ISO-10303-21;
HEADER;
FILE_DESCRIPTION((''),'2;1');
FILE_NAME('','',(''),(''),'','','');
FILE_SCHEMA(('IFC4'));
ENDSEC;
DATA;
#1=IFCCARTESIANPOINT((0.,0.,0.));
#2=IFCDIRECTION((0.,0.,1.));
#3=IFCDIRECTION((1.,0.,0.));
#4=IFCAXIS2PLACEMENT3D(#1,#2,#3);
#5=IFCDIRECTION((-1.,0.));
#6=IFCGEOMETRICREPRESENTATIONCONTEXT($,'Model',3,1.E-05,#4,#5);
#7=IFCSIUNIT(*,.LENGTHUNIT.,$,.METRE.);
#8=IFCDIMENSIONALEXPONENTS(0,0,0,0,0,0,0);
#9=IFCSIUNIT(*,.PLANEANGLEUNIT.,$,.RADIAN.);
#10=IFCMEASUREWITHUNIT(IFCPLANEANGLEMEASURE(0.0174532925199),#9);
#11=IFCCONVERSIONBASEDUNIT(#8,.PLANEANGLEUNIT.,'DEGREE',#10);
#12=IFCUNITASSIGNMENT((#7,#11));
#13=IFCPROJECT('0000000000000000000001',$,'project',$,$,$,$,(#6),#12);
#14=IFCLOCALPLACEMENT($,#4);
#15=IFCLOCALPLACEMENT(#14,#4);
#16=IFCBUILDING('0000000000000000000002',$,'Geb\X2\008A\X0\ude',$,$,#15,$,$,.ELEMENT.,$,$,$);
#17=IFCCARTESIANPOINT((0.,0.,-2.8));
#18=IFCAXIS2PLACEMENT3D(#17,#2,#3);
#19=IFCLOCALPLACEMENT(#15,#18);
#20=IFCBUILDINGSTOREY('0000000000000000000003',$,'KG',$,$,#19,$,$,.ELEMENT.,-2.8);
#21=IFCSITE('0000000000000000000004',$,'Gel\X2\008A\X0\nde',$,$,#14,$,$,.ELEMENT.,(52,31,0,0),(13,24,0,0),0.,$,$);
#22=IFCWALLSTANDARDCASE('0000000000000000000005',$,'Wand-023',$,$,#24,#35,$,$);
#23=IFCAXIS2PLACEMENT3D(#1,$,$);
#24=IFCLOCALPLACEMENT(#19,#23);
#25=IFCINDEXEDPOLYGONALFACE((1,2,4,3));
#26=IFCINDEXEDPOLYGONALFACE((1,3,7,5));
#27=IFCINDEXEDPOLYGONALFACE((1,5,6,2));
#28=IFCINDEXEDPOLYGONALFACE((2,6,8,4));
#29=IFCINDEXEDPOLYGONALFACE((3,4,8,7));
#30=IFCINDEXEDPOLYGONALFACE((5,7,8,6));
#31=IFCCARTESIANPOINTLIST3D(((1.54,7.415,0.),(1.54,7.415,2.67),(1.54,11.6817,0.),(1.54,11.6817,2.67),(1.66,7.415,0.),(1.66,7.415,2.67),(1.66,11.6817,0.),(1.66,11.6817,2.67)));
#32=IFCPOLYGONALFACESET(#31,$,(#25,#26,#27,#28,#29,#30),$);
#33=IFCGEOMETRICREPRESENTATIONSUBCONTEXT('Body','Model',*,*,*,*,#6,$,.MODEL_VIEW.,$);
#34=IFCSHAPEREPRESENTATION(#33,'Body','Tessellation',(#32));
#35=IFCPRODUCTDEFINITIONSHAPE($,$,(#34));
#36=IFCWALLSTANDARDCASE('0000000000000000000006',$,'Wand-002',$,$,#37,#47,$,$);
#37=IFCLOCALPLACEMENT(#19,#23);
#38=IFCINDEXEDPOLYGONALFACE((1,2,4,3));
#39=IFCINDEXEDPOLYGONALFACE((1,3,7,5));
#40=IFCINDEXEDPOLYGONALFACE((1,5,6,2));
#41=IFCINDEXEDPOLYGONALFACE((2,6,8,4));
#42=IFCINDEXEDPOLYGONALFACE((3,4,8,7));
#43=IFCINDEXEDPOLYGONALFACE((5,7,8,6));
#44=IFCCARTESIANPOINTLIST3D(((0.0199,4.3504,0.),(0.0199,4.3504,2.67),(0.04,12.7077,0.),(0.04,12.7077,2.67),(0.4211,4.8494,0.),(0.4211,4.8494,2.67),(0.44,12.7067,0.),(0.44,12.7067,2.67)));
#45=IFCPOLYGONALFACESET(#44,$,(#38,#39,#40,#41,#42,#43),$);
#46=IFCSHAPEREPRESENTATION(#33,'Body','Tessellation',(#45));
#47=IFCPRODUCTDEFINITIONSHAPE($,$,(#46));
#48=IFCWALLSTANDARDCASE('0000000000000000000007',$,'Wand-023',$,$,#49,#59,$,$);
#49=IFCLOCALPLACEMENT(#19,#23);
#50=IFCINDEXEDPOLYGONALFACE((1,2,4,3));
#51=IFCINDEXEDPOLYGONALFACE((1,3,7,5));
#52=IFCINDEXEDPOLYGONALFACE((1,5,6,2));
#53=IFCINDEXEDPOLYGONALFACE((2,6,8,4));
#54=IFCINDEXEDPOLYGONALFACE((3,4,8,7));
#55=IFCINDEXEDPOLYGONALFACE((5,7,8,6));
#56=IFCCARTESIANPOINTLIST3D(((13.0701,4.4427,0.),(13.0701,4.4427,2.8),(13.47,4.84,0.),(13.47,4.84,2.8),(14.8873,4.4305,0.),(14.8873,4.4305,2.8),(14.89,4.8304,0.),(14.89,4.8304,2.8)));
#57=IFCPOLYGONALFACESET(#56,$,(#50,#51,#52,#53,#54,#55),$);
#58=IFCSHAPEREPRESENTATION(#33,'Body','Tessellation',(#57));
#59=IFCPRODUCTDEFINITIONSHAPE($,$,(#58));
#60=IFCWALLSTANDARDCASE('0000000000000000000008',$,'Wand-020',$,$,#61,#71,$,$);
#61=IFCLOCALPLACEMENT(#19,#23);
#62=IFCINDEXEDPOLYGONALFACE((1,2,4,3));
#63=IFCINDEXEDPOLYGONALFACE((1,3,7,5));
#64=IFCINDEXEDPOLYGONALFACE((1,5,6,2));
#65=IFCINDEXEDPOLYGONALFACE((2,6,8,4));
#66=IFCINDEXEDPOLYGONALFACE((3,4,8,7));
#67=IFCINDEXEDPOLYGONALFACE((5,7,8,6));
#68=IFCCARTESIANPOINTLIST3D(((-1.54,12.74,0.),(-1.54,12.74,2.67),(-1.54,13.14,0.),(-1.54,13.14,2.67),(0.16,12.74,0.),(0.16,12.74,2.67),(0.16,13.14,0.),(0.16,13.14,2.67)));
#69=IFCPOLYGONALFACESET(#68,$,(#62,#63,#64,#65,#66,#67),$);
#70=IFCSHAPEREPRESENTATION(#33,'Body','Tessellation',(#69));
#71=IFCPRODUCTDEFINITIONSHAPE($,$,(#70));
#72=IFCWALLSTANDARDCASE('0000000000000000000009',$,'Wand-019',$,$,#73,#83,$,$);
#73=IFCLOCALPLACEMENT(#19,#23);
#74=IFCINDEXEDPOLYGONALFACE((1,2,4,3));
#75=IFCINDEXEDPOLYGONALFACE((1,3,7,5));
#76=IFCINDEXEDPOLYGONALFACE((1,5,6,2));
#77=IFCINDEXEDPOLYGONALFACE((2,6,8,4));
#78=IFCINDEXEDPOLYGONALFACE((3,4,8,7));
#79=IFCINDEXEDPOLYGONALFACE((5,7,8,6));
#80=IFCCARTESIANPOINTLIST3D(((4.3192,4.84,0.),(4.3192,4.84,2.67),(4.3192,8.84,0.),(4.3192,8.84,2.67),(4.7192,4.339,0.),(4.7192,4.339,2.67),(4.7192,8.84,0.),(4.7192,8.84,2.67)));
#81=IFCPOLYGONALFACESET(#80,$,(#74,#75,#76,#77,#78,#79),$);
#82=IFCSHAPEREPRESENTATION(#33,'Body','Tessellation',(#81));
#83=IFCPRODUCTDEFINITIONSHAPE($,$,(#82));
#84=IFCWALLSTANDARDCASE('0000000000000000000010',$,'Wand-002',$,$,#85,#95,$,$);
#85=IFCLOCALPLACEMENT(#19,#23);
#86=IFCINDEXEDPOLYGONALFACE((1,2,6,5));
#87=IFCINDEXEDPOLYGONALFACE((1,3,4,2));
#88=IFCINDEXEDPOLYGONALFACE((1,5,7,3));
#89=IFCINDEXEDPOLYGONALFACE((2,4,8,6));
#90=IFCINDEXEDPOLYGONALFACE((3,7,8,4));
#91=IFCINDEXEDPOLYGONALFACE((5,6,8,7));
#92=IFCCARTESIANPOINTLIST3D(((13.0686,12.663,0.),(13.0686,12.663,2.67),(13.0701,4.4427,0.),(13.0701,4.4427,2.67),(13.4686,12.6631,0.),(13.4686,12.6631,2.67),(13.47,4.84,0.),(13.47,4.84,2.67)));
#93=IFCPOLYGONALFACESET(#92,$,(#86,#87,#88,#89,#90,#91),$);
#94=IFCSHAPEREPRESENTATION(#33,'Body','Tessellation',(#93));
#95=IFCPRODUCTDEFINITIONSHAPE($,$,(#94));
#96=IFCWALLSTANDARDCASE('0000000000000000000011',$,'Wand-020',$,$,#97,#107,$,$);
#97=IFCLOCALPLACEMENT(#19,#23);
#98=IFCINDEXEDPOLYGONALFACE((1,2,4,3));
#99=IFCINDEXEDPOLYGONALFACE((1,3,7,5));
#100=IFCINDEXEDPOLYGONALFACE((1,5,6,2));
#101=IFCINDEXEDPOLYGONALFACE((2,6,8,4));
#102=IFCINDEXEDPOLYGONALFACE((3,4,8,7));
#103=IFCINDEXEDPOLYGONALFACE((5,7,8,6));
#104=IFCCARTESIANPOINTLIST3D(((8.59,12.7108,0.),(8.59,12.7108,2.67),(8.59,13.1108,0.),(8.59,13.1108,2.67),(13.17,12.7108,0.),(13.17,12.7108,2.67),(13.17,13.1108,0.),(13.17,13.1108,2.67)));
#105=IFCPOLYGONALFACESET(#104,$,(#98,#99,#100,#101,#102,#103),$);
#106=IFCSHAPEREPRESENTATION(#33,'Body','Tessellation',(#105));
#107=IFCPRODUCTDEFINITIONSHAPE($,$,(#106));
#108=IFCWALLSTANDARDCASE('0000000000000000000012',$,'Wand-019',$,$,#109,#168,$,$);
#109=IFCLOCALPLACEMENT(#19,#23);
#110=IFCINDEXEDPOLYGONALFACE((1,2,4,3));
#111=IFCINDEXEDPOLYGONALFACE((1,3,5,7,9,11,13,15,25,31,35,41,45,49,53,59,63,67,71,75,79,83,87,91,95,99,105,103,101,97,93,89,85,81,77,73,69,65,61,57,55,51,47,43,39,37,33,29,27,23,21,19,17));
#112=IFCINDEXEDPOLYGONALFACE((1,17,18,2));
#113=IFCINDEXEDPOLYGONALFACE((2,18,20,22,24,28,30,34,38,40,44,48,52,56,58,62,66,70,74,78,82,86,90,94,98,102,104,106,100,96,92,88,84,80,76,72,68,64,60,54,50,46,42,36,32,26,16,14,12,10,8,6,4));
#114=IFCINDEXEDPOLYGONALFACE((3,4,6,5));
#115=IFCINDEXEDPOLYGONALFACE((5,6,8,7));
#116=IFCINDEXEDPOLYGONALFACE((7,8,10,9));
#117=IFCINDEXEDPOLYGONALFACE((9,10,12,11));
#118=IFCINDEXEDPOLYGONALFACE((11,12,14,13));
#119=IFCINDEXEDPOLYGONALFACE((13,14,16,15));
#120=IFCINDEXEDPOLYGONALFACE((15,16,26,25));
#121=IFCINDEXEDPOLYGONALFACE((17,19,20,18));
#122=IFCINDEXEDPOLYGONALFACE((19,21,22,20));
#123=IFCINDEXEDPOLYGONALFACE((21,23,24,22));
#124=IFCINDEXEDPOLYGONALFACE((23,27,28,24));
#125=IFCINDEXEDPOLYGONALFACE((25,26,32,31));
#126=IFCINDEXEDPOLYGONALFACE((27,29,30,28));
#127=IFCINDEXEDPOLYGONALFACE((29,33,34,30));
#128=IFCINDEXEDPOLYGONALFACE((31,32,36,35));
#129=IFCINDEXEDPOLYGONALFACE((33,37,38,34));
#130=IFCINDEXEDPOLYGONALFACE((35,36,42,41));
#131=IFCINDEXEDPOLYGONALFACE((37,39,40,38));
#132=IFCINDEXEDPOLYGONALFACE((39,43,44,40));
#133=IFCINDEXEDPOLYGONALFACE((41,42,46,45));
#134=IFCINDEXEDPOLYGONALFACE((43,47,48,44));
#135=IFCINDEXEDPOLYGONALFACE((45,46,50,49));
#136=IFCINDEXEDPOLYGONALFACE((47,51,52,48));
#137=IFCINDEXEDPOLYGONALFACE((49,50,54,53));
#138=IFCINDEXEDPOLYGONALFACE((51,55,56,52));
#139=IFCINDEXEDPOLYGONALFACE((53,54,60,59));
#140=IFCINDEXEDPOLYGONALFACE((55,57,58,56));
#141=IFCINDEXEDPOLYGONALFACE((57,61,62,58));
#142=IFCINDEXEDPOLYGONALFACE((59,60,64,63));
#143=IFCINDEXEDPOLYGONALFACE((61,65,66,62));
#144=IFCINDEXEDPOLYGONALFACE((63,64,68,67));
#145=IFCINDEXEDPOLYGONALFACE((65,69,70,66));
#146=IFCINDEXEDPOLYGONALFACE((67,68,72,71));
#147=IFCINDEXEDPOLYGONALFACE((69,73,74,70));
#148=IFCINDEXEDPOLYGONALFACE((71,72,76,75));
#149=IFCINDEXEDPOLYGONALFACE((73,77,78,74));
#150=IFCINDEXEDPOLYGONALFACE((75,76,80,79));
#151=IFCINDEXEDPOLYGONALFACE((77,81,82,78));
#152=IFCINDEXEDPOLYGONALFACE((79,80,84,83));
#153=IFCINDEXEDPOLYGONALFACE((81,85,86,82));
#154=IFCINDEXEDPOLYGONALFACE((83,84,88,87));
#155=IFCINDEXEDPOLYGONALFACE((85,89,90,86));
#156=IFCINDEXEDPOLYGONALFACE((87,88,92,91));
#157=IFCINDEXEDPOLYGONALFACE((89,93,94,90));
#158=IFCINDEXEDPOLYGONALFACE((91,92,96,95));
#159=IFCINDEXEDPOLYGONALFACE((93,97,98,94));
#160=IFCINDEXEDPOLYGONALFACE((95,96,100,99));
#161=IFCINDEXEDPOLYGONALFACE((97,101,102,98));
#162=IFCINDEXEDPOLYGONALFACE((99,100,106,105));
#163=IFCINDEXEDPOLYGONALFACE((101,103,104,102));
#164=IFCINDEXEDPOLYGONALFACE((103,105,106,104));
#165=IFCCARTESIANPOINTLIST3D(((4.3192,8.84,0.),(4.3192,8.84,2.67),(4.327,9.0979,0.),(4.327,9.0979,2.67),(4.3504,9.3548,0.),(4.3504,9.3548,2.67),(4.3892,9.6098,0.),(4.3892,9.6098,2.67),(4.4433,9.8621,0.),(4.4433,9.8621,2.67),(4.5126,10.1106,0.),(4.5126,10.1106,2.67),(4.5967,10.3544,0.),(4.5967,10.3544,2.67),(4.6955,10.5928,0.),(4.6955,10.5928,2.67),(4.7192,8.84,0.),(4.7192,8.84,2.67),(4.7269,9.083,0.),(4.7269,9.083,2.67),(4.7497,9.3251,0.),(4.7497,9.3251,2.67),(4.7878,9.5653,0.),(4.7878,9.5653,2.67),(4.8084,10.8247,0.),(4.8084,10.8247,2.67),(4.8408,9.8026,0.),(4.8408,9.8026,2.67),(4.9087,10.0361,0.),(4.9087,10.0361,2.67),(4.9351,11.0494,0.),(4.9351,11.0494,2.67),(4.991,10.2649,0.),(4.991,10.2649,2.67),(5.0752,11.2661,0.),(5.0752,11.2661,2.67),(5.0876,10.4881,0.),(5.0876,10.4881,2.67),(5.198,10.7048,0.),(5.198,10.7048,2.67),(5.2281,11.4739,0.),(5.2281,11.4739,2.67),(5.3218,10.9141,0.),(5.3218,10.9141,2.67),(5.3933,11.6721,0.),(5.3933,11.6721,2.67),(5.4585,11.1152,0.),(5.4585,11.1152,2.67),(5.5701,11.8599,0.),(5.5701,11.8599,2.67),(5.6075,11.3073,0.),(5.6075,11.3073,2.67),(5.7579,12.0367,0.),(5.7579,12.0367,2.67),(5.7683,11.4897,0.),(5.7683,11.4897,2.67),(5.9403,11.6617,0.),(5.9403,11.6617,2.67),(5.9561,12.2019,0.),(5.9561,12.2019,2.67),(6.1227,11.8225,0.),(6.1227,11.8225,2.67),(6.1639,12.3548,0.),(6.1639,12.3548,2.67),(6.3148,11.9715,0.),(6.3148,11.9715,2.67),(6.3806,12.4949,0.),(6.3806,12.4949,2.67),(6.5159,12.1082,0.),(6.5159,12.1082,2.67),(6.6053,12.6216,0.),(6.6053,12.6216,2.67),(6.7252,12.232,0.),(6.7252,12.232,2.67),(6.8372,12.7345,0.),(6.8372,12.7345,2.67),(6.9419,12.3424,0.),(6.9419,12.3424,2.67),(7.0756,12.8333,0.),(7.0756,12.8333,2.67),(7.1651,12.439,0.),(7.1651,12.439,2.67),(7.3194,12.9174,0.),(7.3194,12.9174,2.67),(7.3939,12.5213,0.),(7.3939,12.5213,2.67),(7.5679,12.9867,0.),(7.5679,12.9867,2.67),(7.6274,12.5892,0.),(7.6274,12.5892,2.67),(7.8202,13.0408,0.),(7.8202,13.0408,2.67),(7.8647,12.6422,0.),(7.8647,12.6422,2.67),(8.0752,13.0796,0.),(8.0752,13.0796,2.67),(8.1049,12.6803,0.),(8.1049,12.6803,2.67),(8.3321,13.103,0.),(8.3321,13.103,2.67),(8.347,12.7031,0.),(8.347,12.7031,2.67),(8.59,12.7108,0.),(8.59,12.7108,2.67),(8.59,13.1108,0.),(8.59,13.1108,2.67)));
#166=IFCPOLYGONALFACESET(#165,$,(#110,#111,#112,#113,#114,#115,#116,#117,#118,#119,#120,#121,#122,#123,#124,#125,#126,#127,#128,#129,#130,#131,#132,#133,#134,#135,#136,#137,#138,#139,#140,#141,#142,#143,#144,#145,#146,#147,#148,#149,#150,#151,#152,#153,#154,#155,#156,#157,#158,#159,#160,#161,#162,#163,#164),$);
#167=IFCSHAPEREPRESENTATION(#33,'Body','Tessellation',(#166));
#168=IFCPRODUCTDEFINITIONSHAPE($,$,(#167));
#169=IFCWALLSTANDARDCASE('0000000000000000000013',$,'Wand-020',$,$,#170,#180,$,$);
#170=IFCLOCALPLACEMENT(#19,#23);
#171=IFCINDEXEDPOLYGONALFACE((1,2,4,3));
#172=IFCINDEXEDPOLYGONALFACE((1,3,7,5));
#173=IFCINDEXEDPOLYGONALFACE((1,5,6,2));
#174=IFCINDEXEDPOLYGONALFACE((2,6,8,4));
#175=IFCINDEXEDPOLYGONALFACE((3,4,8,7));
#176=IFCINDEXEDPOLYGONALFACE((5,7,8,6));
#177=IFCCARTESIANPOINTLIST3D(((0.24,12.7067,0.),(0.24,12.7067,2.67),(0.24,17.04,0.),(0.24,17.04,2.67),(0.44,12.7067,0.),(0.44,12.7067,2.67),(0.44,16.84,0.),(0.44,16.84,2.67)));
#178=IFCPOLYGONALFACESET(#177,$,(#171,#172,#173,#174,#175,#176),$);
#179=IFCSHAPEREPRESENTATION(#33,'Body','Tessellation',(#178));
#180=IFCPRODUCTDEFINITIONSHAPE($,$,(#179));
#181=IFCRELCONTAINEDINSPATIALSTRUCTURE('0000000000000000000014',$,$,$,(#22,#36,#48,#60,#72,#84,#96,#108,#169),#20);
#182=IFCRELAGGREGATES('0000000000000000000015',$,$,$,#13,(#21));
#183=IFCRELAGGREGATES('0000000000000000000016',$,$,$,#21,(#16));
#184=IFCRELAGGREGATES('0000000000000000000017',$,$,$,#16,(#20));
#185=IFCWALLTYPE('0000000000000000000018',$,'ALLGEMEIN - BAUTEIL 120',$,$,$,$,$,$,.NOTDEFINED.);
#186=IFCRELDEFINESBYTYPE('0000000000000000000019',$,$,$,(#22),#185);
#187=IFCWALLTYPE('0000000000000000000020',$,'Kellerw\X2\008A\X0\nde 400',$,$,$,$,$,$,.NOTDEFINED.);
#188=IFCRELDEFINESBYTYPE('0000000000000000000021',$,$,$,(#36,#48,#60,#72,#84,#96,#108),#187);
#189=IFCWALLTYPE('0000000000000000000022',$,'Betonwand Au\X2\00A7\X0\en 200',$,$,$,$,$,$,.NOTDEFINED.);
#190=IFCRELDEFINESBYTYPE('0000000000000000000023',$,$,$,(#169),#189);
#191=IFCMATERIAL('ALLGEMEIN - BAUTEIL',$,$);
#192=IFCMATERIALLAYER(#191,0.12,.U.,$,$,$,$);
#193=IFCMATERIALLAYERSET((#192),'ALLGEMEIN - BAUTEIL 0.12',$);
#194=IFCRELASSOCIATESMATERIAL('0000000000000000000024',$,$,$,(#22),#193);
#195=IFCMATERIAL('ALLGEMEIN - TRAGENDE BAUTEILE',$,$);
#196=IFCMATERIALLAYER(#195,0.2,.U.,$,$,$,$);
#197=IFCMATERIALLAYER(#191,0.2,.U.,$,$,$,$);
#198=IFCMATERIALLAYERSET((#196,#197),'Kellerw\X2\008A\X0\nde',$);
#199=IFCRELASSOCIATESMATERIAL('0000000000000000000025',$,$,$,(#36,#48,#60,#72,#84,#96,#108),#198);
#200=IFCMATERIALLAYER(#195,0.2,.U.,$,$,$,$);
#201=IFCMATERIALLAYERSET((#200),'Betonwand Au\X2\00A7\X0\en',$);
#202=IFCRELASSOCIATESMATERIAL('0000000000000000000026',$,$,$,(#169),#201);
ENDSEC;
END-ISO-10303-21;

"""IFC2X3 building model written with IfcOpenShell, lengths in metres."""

from ifc_helpers import new_model, entity, si_unit, converted_unit, point, direction, frame, frame_2d, origin_with_axes, place, context, subcontext, project, spatial, polyline, circle_curve, parameter, trimmed, segment, composite_curve, outline, extrude, material, layer, layer_set, layer_usage, type_object, element, save


model = new_model("IFC2X3")

# Units and contexts
model_context = context("Model", 3, precision=1e-05, world=origin_with_axes(), true_north=direction((-1.0, 0.0)))
body_context = subcontext(model_context, "Body", "Model", "MODEL_VIEW")
ifc_project = project(units=[si_unit("LENGTHUNIT", "METRE"), converted_unit("PLANEANGLEUNIT", "DEGREE", entity("IfcPlaneAngleMeasure", 0.0174532925199), si_unit("PLANEANGLEUNIT", "RADIAN"), dimensions=[0, 0, 0, 0, 0, 0, 0])], contexts=[model_context])

# Site, building, storey
site_placement = place(None, origin_with_axes())
site = spatial("IfcSite", under=ifc_project, at=site_placement, Name="Gel\u008ande", CompositionType="ELEMENT", RefLatitude=(52, 31, 0, 0), RefLongitude=(13, 24, 0, 0), RefElevation=0.0)
building_placement = place(site_placement, origin_with_axes())
building = spatial("IfcBuilding", under=site, at=building_placement, Name="Geb\u008aude", CompositionType="ELEMENT")
storey_placement = place(building_placement, frame((0.0, 0.0, -2.8), z_axis=(0.0, 0.0, 1.0), x_axis=(1.0, 0.0, 0.0)))
storey = spatial("IfcBuildingStorey", under=building, at=storey_placement, Name="KG", CompositionType="ELEMENT", Elevation=-2.8)

# Shared definitions
ifc_material_1 = material(Name="ALLGEMEIN - BAUTEIL")
ifc_material_2 = material(Name="ALLGEMEIN - TRAGENDE BAUTEILE")

# Walls
ifc_layer_1 = layer(ifc_material_1, 0.12, ventilated="UNKNOWN")
ifc_layer_set_1 = layer_set([ifc_layer_1], Name="ALLGEMEIN - BAUTEIL 0.12")
ifc_layer_usage_1 = layer_usage(ifc_layer_set_1, "AXIS2", "POSITIVE", 0.0)
wall_type_1 = type_object("IfcWallType", Name="ALLGEMEIN - BAUTEIL 120", PredefinedType="NOTDEFINED")
wall_1_placement = place(storey_placement, frame((1.54, 11.6817, 0.0), z_axis=(0.0, 0.0, 1.0), x_axis=(0.0, -1.0, 0.0)))
element("IfcWallStandardCase", 1, at=wall_1_placement, inside=storey, type_object=wall_type_1, material=ifc_layer_usage_1, Name="Wand-023", context=body_context, shape_type="SweptSolid", body=[
    extrude(outline(polyline([(0.0, 0.0), (4.2667, 0.0), (4.2667, 0.12), (0.0, 0.12), (0.0, 0.0)])), origin_with_axes(), (0.0, 0.0, 1.0), 2.67),
])
ifc_layer_2 = layer(ifc_material_2, 0.2, ventilated="UNKNOWN")
ifc_layer_3 = layer(ifc_material_1, 0.2, ventilated="UNKNOWN")
ifc_layer_set_2 = layer_set([ifc_layer_2, ifc_layer_3], Name="Kellerw\u008ande")
ifc_layer_usage_2 = layer_usage(ifc_layer_set_2, "AXIS2", "POSITIVE", 0.0)
wall_type_2 = type_object("IfcWallType", Name="Kellerw\u008ande 400", PredefinedType="NOTDEFINED")
wall_2_placement = place(storey_placement, frame((0.4211, 4.8494, 0.0), z_axis=(0.0, 0.0, 1.0), x_axis=(0.002408, 0.999997, 0.0)))
element("IfcWallStandardCase", 2, at=wall_2_placement, inside=storey, type_object=wall_type_2, material=ifc_layer_usage_2, Name="Wand-002", context=body_context, shape_type="SweptSolid", body=[
    extrude(outline(polyline([(0.0, 0.0), (7.8574, 0.0), (7.8574, 0.4), (-0.5, 0.4), (0.0, 0.0)])), origin_with_axes(), (0.0, 0.0, 1.0), 2.67),
])
ifc_layer_usage_3 = layer_usage(ifc_layer_set_2, "AXIS2", "NEGATIVE", 0.0)
wall_3_placement = place(storey_placement, frame((13.47, 4.84, 0.0), z_axis=(0.0, 0.0, 1.0), x_axis=(0.999977, -0.006727, 0.0)))
element("IfcWallStandardCase", 3, at=wall_3_placement, inside=storey, type_object=wall_type_2, material=ifc_layer_usage_3, Name="Wand-023", context=body_context, shape_type="SweptSolid", body=[
    extrude(outline(polyline([(-0.3972, -0.4), (1.42, -0.4), (1.42, 0.0), (0.0, 0.0), (-0.3972, -0.4)])), origin_with_axes(), (0.0, 0.0, 1.0), 2.8),
])
ifc_layer_usage_4 = layer_usage(ifc_layer_set_2, "AXIS2", "NEGATIVE", 0.0)
wall_4_placement = place(storey_placement, frame((-1.54, 13.14, 0.0), z_axis=(0.0, 0.0, 1.0), x_axis=(1.0, 0.0, 0.0)))
element("IfcWallStandardCase", 4, at=wall_4_placement, inside=storey, type_object=wall_type_2, material=ifc_layer_usage_4, Name="Wand-020", context=body_context, shape_type="SweptSolid", body=[
    extrude(outline(polyline([(0.0, -0.4), (1.7, -0.4), (1.7, 0.0), (0.0, 0.0), (0.0, -0.4)])), origin_with_axes(), (0.0, 0.0, 1.0), 2.67),
])
ifc_layer_usage_5 = layer_usage(ifc_layer_set_2, "AXIS2", "NEGATIVE", 0.0)
wall_5_placement = place(storey_placement, frame((4.3192, 4.84, 0.0), z_axis=(0.0, 0.0, 1.0), x_axis=(0.0, 1.0, 0.0)))
element("IfcWallStandardCase", 5, at=wall_5_placement, inside=storey, type_object=wall_type_2, material=ifc_layer_usage_5, Name="Wand-019", context=body_context, shape_type="SweptSolid", body=[
    extrude(outline(polyline([(-0.501, -0.4), (4.0, -0.4), (4.0, 0.0), (0.0, 0.0), (-0.501, -0.4)])), origin_with_axes(), (0.0, 0.0, 1.0), 2.67),
])
ifc_layer_usage_6 = layer_usage(ifc_layer_set_2, "AXIS2", "POSITIVE", 0.0)
wall_6_placement = place(storey_placement, frame((13.47, 4.84, 0.0), z_axis=(0.0, 0.0, 1.0), x_axis=(-0.00018, 1.0, 0.0)))
element("IfcWallStandardCase", 6, at=wall_6_placement, inside=storey, type_object=wall_type_2, material=ifc_layer_usage_6, Name="Wand-002", context=body_context, shape_type="SweptSolid", body=[
    extrude(outline(polyline([(0.0, 0.0), (7.8231, 0.0), (7.8231, 0.4), (-0.3972, 0.4), (0.0, 0.0)])), origin_with_axes(), (0.0, 0.0, 1.0), 2.67),
])
ifc_layer_usage_7 = layer_usage(ifc_layer_set_2, "AXIS2", "NEGATIVE", 0.0)
wall_7_placement = place(storey_placement, frame((8.59, 13.1108, 0.0), z_axis=(0.0, 0.0, 1.0), x_axis=(1.0, 0.0, 0.0)))
element("IfcWallStandardCase", 7, at=wall_7_placement, inside=storey, type_object=wall_type_2, material=ifc_layer_usage_7, Name="Wand-020", context=body_context, shape_type="SweptSolid", body=[
    extrude(outline(polyline([(0.0, -0.4), (4.58, -0.4), (4.58, 0.0), (0.0, 0.0), (0.0, -0.4)])), origin_with_axes(), (0.0, 0.0, 1.0), 2.67),
])
ifc_layer_usage_8 = layer_usage(ifc_layer_set_2, "AXIS2", "POSITIVE", 0.0)
wall_8_placement = place(storey_placement, frame((8.59, 13.1108, 0.0), z_axis=(0.0, 0.0, 1.0), x_axis=(-1.0, 0.0, 0.0)))
element("IfcWallStandardCase", 8, at=wall_8_placement, inside=storey, type_object=wall_type_2, material=ifc_layer_usage_8, Name="Wand-019", context=body_context, shape_type="SweptSolid", body=[
    extrude(outline(composite_curve([segment(trimmed(circle_curve(frame_2d((0.0, 4.2708), x_axis=(0.0, -1.0)), 3.8708), [point((3.8708, 4.2708)), parameter(90.0)], [point((0.0, 0.4)), parameter(0.0)], False, "CARTESIAN"), True, "CONTINUOUS"), segment(polyline([(0.0, 0.4), (0.0, 0.0)]), True, "CONTINUOUS"), segment(trimmed(circle_curve(frame_2d((0.0, 4.2708), x_axis=(0.0, -1.0)), 4.2708), [point((0.0, 0.0)), parameter(0.0)], [point((4.2708, 4.2708)), parameter(90.0)], True, "CARTESIAN"), True, "CONTINUOUS"), segment(polyline([(4.2708, 4.2708), (3.8708, 4.2708)]), True, "CONTINUOUS")], self_intersect=False)), origin_with_axes(), (0.0, 0.0, 1.0), 2.67),
])
ifc_layer_4 = layer(ifc_material_2, 0.2, ventilated="UNKNOWN")
ifc_layer_set_3 = layer_set([ifc_layer_4], Name="Betonwand Au§en")
ifc_layer_usage_9 = layer_usage(ifc_layer_set_3, "AXIS2", "NEGATIVE", 0.2)
wall_type_3 = type_object("IfcWallType", Name="Betonwand Au§en 200", PredefinedType="NOTDEFINED")
wall_9_placement = place(storey_placement, frame((0.44, 12.7067, 0.0), z_axis=(0.0, 0.0, 1.0), x_axis=(0.0, 1.0, 0.0)))
element("IfcWallStandardCase", 9, at=wall_9_placement, inside=storey, type_object=wall_type_3, material=ifc_layer_usage_9, Name="Wand-020", context=body_context, shape_type="SweptSolid", body=[
    extrude(outline(polyline([(0.0, 0.0), (4.1333, 0.0), (4.3333, 0.2), (0.0, 0.2), (0.0, 0.0)])), origin_with_axes(), (0.0, 0.0, 1.0), 2.67),
])

save(model, "model.ifc")
